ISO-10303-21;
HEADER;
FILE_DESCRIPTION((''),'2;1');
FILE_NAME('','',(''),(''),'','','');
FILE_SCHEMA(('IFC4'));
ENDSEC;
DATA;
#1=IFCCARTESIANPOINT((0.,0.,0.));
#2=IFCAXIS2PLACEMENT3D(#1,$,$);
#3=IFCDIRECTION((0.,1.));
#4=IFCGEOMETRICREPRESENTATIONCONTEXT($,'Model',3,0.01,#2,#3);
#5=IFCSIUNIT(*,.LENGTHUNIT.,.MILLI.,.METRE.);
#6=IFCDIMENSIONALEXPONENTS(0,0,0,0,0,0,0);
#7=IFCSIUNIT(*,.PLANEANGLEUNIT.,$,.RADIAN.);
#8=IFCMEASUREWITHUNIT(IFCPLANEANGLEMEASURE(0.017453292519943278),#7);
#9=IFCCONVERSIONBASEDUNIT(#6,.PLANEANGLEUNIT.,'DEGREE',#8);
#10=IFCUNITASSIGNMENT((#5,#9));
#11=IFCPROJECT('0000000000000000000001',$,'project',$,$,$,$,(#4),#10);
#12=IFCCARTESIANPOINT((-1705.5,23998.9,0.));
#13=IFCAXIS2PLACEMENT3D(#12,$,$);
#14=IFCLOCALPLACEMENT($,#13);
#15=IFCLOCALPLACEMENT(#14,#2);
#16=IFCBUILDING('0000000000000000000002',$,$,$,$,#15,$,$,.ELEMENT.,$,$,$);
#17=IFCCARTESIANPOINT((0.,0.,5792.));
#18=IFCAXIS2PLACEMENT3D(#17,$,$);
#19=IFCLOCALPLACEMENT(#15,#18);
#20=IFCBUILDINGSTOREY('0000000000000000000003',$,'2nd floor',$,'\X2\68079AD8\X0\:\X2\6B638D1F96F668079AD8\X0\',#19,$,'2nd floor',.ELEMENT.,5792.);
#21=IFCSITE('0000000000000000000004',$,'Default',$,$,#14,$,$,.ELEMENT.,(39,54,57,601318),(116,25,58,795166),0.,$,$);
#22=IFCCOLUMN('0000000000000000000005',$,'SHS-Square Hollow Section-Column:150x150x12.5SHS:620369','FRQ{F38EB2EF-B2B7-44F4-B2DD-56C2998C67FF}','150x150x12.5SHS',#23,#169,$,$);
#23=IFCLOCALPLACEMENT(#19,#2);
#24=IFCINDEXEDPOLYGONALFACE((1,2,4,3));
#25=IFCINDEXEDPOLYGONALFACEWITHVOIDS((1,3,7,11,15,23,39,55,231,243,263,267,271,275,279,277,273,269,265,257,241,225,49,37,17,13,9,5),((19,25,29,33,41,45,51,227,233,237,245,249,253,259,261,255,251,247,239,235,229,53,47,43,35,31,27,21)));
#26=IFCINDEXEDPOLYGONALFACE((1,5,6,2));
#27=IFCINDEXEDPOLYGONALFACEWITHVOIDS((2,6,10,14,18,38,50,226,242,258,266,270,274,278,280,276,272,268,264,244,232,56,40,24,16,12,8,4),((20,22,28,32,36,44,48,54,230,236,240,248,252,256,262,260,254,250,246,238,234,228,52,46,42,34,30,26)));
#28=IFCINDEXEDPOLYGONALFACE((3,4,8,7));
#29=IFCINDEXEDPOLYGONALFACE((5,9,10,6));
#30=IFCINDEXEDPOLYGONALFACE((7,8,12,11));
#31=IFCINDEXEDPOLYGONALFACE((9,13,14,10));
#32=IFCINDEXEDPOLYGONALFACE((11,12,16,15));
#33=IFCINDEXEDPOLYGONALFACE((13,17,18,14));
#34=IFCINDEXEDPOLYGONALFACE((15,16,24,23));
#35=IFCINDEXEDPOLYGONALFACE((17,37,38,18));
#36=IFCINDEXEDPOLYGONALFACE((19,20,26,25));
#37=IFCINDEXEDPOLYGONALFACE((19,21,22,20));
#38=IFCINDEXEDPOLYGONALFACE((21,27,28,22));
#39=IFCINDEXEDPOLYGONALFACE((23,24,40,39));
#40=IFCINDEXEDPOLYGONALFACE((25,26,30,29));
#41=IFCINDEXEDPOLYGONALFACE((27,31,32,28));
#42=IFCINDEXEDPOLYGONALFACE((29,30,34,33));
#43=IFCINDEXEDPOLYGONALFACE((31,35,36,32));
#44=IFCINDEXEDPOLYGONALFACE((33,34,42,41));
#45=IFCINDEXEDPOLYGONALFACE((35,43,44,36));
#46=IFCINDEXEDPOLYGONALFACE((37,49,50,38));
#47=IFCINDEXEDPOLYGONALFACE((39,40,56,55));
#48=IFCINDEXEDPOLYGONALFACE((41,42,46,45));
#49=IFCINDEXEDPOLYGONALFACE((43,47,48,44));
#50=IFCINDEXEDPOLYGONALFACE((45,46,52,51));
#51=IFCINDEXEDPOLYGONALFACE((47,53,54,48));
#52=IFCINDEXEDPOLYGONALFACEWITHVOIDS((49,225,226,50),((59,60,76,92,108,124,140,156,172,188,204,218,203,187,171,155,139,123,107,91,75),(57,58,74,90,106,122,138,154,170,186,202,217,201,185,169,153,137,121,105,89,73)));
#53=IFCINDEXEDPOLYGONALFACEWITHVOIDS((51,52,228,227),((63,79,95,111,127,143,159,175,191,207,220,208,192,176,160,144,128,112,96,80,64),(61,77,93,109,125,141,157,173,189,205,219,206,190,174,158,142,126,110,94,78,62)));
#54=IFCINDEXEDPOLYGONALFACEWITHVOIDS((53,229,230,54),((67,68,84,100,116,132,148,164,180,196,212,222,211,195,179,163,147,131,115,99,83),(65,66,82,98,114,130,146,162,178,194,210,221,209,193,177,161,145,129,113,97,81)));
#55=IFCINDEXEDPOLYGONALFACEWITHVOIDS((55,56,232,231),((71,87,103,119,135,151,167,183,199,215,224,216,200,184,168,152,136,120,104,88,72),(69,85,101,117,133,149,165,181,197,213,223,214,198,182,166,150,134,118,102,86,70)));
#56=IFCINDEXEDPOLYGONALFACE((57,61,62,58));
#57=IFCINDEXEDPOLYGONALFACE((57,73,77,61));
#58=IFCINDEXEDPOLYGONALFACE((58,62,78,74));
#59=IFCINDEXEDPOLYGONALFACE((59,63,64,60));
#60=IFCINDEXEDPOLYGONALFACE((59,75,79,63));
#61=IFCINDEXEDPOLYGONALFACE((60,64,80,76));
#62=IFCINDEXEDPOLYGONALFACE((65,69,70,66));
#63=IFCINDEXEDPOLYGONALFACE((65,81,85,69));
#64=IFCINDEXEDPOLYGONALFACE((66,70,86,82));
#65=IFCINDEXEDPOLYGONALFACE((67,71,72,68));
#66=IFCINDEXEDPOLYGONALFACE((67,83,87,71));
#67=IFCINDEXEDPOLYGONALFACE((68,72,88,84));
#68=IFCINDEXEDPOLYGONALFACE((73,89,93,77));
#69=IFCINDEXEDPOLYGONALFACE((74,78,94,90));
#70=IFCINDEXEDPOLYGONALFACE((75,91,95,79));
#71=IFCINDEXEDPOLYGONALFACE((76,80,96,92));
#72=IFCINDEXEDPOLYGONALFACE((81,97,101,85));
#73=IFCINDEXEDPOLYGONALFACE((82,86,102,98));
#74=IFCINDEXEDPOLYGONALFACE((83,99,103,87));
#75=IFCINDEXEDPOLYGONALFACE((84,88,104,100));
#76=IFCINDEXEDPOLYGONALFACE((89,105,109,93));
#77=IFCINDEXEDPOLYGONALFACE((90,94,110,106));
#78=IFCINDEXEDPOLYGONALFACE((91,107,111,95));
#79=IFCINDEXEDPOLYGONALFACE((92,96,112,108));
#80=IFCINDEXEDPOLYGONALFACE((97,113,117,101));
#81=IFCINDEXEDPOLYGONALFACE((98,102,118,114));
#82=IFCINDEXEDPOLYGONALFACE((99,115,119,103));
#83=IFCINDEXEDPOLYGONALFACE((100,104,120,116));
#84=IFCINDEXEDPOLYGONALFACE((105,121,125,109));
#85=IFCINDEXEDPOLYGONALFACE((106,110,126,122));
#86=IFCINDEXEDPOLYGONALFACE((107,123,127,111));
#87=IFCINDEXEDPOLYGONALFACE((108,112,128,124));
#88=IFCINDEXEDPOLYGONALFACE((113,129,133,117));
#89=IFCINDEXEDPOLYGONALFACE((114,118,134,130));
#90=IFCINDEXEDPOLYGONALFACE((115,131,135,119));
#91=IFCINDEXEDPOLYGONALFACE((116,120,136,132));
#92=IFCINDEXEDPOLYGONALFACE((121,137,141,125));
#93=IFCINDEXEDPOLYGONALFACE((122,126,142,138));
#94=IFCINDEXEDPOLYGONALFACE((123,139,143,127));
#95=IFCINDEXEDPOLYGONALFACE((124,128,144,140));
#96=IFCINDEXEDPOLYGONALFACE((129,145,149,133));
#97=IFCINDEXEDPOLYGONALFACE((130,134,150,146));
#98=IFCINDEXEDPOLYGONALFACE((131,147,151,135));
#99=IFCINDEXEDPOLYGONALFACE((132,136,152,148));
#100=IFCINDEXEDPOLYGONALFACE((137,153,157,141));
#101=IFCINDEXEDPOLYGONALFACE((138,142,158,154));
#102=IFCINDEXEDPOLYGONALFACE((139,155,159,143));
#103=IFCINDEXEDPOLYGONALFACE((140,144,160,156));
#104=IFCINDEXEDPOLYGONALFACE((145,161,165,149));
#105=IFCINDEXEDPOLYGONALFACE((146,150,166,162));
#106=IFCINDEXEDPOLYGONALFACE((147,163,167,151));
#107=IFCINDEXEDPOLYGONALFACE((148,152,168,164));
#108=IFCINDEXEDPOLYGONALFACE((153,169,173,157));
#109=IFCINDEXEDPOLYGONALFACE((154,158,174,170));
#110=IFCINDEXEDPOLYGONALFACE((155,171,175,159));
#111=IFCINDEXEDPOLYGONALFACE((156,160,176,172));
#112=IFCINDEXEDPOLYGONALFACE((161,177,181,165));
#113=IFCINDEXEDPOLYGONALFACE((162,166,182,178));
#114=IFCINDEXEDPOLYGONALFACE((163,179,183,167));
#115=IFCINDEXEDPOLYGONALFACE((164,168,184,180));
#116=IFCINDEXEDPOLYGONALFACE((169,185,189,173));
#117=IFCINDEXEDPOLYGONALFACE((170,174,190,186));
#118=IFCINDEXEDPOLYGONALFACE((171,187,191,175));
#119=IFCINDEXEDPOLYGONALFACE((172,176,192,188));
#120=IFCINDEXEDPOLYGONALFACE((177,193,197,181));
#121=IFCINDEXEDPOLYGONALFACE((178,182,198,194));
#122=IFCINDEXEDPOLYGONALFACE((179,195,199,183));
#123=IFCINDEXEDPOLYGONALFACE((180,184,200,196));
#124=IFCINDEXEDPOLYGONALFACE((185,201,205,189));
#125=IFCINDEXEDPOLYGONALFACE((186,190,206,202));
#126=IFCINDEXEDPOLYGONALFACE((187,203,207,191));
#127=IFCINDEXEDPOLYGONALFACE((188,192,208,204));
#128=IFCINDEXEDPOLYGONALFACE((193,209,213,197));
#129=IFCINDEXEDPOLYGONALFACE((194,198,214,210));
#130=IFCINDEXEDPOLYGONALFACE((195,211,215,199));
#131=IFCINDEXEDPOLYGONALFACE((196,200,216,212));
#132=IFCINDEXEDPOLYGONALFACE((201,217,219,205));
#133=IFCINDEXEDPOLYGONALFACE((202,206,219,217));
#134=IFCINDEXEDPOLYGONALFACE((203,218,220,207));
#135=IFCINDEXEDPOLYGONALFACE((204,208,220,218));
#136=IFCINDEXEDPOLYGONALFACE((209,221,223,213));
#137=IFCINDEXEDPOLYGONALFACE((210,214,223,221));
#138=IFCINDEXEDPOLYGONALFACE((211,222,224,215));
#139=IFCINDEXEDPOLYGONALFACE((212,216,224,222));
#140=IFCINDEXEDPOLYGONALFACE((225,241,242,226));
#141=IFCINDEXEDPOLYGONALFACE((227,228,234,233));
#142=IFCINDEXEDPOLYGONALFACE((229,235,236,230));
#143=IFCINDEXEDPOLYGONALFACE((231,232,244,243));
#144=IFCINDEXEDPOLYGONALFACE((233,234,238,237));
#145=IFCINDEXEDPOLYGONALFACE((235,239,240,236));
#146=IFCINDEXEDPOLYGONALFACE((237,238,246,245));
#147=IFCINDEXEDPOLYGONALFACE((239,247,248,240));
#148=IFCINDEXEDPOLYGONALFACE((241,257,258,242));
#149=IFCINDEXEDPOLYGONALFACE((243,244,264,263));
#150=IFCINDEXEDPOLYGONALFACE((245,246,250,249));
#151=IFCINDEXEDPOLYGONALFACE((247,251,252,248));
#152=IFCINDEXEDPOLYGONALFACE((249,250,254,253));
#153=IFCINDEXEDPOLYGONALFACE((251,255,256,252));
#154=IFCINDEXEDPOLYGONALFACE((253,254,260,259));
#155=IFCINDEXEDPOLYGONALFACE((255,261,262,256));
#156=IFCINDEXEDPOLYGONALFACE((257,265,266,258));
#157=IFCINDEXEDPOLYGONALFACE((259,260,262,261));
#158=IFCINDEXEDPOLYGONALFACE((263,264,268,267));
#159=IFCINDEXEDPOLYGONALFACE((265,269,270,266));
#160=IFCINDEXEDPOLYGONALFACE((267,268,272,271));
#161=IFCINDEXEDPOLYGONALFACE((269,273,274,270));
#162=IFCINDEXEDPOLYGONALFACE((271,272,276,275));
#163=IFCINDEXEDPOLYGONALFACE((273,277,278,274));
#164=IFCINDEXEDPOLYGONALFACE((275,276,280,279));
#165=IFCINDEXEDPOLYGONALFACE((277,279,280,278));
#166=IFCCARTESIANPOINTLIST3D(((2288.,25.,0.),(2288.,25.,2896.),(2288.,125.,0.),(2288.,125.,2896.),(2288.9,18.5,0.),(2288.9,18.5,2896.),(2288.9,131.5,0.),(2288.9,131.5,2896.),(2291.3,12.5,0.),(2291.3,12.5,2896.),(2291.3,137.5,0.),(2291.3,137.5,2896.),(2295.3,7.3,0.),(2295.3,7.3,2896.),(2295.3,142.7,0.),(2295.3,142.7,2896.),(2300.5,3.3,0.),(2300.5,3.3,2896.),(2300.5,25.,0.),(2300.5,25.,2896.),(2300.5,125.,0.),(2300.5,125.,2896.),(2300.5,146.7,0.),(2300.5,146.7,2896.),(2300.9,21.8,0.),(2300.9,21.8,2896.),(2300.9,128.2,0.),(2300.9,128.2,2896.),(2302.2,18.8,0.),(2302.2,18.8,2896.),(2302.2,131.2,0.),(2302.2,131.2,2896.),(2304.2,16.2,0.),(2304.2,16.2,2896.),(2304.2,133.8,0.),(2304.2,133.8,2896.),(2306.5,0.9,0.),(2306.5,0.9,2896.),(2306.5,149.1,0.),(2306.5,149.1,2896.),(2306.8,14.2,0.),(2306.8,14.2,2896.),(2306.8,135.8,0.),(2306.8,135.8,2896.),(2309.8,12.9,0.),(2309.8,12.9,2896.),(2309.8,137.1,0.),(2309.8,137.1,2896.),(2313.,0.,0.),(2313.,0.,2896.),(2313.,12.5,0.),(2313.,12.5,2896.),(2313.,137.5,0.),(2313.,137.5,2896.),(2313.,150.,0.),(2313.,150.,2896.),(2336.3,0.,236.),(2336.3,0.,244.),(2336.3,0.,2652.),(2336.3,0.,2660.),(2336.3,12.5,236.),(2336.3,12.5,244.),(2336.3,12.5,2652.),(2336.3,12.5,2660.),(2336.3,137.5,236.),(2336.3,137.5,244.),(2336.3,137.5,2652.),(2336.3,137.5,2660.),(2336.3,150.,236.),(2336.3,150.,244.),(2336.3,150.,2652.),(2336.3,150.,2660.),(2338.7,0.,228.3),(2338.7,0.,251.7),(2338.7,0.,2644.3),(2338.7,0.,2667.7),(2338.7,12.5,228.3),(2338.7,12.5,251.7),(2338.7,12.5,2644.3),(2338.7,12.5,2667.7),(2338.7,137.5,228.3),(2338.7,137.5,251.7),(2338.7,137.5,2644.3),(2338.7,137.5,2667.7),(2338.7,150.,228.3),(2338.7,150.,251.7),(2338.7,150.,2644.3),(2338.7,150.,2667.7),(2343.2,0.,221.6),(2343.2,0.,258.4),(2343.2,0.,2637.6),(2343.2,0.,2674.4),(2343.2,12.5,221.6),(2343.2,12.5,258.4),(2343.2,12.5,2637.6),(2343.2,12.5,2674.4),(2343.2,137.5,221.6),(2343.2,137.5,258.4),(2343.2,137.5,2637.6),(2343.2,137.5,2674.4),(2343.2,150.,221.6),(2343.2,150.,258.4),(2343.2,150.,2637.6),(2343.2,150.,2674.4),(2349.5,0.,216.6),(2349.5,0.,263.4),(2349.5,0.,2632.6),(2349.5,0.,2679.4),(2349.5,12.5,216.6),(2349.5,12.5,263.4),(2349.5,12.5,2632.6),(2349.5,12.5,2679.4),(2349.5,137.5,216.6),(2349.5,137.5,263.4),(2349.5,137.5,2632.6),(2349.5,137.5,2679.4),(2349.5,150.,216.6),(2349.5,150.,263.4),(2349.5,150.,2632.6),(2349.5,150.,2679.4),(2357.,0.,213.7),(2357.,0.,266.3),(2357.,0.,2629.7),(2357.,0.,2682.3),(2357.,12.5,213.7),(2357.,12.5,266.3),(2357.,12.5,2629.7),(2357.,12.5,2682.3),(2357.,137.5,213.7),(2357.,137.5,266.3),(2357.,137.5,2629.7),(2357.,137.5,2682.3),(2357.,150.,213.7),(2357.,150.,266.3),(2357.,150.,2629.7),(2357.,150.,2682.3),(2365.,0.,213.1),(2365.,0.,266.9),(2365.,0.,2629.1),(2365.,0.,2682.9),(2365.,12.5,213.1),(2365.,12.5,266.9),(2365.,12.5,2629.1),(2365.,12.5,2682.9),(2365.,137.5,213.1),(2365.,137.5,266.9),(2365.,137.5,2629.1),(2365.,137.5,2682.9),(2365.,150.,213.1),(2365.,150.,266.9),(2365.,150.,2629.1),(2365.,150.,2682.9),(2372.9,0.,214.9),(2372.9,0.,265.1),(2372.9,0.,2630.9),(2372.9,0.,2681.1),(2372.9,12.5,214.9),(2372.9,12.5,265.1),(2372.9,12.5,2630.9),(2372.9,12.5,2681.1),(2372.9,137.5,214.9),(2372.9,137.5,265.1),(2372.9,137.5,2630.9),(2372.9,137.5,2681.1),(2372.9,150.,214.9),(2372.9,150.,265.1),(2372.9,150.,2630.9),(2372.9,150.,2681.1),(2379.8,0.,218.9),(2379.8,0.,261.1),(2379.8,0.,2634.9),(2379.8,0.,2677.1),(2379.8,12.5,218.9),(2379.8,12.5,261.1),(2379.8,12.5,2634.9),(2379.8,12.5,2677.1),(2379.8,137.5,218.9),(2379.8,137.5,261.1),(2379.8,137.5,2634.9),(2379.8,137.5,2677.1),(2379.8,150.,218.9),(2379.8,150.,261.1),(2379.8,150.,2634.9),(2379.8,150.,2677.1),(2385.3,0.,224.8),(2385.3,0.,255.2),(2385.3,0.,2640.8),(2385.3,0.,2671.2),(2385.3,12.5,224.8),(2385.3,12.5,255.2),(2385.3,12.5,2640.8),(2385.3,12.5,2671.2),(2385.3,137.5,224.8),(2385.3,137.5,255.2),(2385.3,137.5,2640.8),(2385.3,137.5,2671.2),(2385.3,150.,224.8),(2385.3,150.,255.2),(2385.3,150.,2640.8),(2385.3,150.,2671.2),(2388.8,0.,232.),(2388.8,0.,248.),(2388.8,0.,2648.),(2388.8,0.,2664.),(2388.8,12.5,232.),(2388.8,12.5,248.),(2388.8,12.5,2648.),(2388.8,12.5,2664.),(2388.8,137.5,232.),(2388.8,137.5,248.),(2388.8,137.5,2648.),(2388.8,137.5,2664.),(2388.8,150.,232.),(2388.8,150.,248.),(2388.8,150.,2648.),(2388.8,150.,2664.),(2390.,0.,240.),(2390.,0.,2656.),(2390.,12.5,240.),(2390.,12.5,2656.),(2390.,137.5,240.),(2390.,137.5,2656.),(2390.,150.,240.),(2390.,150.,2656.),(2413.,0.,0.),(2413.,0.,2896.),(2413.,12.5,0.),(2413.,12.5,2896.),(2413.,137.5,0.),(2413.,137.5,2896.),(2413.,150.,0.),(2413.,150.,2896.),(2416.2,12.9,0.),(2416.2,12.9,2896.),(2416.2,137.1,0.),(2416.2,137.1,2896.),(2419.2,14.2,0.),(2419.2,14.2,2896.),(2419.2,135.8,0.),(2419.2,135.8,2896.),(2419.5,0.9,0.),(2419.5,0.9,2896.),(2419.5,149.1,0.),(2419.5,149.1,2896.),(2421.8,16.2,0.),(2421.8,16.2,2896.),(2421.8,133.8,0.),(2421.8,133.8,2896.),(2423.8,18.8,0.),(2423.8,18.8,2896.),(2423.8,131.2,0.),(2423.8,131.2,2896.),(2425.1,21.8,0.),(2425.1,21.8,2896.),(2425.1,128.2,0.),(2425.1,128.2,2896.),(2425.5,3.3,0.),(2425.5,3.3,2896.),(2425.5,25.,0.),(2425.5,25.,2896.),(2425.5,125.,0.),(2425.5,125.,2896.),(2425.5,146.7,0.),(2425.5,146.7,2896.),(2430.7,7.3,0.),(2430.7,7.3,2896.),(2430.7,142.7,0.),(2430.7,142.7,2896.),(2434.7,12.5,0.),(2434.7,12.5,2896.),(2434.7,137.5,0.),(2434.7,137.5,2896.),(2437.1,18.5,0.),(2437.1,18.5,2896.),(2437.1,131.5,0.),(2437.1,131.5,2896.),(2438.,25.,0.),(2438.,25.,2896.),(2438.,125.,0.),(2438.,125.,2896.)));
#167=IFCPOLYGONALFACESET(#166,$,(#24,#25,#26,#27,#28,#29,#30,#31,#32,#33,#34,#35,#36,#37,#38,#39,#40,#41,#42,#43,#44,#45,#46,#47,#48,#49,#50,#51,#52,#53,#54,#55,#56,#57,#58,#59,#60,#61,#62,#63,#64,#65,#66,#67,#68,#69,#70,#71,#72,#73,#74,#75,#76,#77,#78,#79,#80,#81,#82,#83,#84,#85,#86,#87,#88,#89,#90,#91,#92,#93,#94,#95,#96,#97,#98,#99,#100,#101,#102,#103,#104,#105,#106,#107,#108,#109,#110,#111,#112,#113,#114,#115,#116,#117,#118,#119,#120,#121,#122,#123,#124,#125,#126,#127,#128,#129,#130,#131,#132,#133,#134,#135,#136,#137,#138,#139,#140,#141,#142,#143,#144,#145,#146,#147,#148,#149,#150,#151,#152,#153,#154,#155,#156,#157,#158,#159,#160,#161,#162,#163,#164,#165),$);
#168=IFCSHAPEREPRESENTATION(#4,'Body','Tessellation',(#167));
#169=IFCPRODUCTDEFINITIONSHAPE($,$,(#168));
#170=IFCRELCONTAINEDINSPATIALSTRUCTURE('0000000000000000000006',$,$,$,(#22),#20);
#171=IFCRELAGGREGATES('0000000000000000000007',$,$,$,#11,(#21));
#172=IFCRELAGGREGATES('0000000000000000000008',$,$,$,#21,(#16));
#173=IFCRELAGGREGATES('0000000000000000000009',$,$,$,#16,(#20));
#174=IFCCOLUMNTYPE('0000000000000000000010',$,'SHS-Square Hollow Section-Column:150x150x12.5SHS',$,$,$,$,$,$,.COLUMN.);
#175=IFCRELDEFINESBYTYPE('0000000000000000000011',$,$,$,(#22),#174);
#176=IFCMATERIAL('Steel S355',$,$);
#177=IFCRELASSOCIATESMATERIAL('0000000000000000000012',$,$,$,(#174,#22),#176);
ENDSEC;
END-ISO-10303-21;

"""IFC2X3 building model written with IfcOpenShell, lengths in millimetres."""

from ifc_helpers import new_model, entity, si_unit, converted_unit, direction, frame, frame_2d, origin, origin_2d, place, context, project, spatial, circle_curve, hollow_rectangle, outline, extrude, material, type_object, element, save


model = new_model("IFC2X3")

# Units and contexts
model_context = context("Model", 3, precision=0.01, world=origin(), true_north=direction((0.0, 1.0)))
ifc_project = project(units=[si_unit("LENGTHUNIT", "METRE", prefix="MILLI"), converted_unit("PLANEANGLEUNIT", "DEGREE", entity("IfcPlaneAngleMeasure", 0.017453292519943278), si_unit("PLANEANGLEUNIT", "RADIAN"), dimensions=[0, 0, 0, 0, 0, 0, 0])], contexts=[model_context])

# Site, building, storey
site_placement = place(None, frame((-1705.5, 23998.9, 0.0)))
site = spatial("IfcSite", under=ifc_project, at=site_placement, Name="Default", CompositionType="ELEMENT", RefLatitude=(39, 54, 57, 601318), RefLongitude=(116, 25, 58, 795166), RefElevation=0.0)
building_placement = place(site_placement, origin())
building = spatial("IfcBuilding", under=site, at=building_placement, CompositionType="ELEMENT")
storey_placement = place(building_placement, frame((0.0, 0.0, 5792.0)))
storey = spatial("IfcBuildingStorey", under=building, at=storey_placement, Name="2nd floor", ObjectType="标高:正负零标高", LongName="2nd floor", CompositionType="ELEMENT", Elevation=5792.0)

# Shared definitions
ifc_material_1 = material(Name="Steel S355")

# Column, openings
column_type_1 = type_object("IfcColumnType", Name="SHS-Square Hollow Section-Column:150x150x12.5SHS", PredefinedType="COLUMN", material=ifc_material_1)
column_1_placement = place(storey_placement, frame((2363.0, 75.0, 2896.0), z_axis=(0.0, 0.0, 1.0), x_axis=(0.0, -1.0, 0.0)))
column_1 = element("IfcColumn", 1, at=column_1_placement, inside=storey, type_object=column_type_1, material=ifc_material_1, Name="SHS-Square Hollow Section-Column:150x150x12.5SHS:620369", Description="FRQ{F38EB2EF-B2B7-44F4-B2DD-56C2998C67FF}", ObjectType="150x150x12.5SHS", context=model_context, shape_type="SweptSolid", body=[
    extrude(hollow_rectangle(XDim=150.0, YDim=150.0, WallThickness=12.5, InnerFilletRadius=12.5, OuterFilletRadius=25.0, at=origin_2d()), origin(), (0.0, 0.0, -1.0), 2896.0),
])
opening_1_placement = place(column_1_placement, frame((-175.1, 0.0, -2896.0), z_axis=(1.0, 0.0, 0.0), x_axis=(0.0, 1.0, 0.0)))
element("IfcOpeningElement", 2, at=opening_1_placement, cuts=column_1, ObjectType="Opening", context=model_context, shape_type="SweptSolid", body=[
    extrude(outline(circle_curve(frame_2d((0.0, 240.0), x_axis=(1.0, 0.0)), 27.0)), origin(), (0.0, 0.0, 1.0), 350.2),
])
opening_2_placement = place(column_1_placement, frame((-175.1, 0.0, 0.0), z_axis=(1.0, 0.0, 0.0), x_axis=(0.0, 1.0, 0.0)))
element("IfcOpeningElement", 3, at=opening_2_placement, cuts=column_1, ObjectType="Opening", context=model_context, shape_type="SweptSolid", body=[
    extrude(outline(circle_curve(frame_2d((0.0, -240.0), x_axis=(1.0, 0.0)), 27.0)), origin(), (0.0, 0.0, 1.0), 350.2),
])

save(model, "model.ifc")
